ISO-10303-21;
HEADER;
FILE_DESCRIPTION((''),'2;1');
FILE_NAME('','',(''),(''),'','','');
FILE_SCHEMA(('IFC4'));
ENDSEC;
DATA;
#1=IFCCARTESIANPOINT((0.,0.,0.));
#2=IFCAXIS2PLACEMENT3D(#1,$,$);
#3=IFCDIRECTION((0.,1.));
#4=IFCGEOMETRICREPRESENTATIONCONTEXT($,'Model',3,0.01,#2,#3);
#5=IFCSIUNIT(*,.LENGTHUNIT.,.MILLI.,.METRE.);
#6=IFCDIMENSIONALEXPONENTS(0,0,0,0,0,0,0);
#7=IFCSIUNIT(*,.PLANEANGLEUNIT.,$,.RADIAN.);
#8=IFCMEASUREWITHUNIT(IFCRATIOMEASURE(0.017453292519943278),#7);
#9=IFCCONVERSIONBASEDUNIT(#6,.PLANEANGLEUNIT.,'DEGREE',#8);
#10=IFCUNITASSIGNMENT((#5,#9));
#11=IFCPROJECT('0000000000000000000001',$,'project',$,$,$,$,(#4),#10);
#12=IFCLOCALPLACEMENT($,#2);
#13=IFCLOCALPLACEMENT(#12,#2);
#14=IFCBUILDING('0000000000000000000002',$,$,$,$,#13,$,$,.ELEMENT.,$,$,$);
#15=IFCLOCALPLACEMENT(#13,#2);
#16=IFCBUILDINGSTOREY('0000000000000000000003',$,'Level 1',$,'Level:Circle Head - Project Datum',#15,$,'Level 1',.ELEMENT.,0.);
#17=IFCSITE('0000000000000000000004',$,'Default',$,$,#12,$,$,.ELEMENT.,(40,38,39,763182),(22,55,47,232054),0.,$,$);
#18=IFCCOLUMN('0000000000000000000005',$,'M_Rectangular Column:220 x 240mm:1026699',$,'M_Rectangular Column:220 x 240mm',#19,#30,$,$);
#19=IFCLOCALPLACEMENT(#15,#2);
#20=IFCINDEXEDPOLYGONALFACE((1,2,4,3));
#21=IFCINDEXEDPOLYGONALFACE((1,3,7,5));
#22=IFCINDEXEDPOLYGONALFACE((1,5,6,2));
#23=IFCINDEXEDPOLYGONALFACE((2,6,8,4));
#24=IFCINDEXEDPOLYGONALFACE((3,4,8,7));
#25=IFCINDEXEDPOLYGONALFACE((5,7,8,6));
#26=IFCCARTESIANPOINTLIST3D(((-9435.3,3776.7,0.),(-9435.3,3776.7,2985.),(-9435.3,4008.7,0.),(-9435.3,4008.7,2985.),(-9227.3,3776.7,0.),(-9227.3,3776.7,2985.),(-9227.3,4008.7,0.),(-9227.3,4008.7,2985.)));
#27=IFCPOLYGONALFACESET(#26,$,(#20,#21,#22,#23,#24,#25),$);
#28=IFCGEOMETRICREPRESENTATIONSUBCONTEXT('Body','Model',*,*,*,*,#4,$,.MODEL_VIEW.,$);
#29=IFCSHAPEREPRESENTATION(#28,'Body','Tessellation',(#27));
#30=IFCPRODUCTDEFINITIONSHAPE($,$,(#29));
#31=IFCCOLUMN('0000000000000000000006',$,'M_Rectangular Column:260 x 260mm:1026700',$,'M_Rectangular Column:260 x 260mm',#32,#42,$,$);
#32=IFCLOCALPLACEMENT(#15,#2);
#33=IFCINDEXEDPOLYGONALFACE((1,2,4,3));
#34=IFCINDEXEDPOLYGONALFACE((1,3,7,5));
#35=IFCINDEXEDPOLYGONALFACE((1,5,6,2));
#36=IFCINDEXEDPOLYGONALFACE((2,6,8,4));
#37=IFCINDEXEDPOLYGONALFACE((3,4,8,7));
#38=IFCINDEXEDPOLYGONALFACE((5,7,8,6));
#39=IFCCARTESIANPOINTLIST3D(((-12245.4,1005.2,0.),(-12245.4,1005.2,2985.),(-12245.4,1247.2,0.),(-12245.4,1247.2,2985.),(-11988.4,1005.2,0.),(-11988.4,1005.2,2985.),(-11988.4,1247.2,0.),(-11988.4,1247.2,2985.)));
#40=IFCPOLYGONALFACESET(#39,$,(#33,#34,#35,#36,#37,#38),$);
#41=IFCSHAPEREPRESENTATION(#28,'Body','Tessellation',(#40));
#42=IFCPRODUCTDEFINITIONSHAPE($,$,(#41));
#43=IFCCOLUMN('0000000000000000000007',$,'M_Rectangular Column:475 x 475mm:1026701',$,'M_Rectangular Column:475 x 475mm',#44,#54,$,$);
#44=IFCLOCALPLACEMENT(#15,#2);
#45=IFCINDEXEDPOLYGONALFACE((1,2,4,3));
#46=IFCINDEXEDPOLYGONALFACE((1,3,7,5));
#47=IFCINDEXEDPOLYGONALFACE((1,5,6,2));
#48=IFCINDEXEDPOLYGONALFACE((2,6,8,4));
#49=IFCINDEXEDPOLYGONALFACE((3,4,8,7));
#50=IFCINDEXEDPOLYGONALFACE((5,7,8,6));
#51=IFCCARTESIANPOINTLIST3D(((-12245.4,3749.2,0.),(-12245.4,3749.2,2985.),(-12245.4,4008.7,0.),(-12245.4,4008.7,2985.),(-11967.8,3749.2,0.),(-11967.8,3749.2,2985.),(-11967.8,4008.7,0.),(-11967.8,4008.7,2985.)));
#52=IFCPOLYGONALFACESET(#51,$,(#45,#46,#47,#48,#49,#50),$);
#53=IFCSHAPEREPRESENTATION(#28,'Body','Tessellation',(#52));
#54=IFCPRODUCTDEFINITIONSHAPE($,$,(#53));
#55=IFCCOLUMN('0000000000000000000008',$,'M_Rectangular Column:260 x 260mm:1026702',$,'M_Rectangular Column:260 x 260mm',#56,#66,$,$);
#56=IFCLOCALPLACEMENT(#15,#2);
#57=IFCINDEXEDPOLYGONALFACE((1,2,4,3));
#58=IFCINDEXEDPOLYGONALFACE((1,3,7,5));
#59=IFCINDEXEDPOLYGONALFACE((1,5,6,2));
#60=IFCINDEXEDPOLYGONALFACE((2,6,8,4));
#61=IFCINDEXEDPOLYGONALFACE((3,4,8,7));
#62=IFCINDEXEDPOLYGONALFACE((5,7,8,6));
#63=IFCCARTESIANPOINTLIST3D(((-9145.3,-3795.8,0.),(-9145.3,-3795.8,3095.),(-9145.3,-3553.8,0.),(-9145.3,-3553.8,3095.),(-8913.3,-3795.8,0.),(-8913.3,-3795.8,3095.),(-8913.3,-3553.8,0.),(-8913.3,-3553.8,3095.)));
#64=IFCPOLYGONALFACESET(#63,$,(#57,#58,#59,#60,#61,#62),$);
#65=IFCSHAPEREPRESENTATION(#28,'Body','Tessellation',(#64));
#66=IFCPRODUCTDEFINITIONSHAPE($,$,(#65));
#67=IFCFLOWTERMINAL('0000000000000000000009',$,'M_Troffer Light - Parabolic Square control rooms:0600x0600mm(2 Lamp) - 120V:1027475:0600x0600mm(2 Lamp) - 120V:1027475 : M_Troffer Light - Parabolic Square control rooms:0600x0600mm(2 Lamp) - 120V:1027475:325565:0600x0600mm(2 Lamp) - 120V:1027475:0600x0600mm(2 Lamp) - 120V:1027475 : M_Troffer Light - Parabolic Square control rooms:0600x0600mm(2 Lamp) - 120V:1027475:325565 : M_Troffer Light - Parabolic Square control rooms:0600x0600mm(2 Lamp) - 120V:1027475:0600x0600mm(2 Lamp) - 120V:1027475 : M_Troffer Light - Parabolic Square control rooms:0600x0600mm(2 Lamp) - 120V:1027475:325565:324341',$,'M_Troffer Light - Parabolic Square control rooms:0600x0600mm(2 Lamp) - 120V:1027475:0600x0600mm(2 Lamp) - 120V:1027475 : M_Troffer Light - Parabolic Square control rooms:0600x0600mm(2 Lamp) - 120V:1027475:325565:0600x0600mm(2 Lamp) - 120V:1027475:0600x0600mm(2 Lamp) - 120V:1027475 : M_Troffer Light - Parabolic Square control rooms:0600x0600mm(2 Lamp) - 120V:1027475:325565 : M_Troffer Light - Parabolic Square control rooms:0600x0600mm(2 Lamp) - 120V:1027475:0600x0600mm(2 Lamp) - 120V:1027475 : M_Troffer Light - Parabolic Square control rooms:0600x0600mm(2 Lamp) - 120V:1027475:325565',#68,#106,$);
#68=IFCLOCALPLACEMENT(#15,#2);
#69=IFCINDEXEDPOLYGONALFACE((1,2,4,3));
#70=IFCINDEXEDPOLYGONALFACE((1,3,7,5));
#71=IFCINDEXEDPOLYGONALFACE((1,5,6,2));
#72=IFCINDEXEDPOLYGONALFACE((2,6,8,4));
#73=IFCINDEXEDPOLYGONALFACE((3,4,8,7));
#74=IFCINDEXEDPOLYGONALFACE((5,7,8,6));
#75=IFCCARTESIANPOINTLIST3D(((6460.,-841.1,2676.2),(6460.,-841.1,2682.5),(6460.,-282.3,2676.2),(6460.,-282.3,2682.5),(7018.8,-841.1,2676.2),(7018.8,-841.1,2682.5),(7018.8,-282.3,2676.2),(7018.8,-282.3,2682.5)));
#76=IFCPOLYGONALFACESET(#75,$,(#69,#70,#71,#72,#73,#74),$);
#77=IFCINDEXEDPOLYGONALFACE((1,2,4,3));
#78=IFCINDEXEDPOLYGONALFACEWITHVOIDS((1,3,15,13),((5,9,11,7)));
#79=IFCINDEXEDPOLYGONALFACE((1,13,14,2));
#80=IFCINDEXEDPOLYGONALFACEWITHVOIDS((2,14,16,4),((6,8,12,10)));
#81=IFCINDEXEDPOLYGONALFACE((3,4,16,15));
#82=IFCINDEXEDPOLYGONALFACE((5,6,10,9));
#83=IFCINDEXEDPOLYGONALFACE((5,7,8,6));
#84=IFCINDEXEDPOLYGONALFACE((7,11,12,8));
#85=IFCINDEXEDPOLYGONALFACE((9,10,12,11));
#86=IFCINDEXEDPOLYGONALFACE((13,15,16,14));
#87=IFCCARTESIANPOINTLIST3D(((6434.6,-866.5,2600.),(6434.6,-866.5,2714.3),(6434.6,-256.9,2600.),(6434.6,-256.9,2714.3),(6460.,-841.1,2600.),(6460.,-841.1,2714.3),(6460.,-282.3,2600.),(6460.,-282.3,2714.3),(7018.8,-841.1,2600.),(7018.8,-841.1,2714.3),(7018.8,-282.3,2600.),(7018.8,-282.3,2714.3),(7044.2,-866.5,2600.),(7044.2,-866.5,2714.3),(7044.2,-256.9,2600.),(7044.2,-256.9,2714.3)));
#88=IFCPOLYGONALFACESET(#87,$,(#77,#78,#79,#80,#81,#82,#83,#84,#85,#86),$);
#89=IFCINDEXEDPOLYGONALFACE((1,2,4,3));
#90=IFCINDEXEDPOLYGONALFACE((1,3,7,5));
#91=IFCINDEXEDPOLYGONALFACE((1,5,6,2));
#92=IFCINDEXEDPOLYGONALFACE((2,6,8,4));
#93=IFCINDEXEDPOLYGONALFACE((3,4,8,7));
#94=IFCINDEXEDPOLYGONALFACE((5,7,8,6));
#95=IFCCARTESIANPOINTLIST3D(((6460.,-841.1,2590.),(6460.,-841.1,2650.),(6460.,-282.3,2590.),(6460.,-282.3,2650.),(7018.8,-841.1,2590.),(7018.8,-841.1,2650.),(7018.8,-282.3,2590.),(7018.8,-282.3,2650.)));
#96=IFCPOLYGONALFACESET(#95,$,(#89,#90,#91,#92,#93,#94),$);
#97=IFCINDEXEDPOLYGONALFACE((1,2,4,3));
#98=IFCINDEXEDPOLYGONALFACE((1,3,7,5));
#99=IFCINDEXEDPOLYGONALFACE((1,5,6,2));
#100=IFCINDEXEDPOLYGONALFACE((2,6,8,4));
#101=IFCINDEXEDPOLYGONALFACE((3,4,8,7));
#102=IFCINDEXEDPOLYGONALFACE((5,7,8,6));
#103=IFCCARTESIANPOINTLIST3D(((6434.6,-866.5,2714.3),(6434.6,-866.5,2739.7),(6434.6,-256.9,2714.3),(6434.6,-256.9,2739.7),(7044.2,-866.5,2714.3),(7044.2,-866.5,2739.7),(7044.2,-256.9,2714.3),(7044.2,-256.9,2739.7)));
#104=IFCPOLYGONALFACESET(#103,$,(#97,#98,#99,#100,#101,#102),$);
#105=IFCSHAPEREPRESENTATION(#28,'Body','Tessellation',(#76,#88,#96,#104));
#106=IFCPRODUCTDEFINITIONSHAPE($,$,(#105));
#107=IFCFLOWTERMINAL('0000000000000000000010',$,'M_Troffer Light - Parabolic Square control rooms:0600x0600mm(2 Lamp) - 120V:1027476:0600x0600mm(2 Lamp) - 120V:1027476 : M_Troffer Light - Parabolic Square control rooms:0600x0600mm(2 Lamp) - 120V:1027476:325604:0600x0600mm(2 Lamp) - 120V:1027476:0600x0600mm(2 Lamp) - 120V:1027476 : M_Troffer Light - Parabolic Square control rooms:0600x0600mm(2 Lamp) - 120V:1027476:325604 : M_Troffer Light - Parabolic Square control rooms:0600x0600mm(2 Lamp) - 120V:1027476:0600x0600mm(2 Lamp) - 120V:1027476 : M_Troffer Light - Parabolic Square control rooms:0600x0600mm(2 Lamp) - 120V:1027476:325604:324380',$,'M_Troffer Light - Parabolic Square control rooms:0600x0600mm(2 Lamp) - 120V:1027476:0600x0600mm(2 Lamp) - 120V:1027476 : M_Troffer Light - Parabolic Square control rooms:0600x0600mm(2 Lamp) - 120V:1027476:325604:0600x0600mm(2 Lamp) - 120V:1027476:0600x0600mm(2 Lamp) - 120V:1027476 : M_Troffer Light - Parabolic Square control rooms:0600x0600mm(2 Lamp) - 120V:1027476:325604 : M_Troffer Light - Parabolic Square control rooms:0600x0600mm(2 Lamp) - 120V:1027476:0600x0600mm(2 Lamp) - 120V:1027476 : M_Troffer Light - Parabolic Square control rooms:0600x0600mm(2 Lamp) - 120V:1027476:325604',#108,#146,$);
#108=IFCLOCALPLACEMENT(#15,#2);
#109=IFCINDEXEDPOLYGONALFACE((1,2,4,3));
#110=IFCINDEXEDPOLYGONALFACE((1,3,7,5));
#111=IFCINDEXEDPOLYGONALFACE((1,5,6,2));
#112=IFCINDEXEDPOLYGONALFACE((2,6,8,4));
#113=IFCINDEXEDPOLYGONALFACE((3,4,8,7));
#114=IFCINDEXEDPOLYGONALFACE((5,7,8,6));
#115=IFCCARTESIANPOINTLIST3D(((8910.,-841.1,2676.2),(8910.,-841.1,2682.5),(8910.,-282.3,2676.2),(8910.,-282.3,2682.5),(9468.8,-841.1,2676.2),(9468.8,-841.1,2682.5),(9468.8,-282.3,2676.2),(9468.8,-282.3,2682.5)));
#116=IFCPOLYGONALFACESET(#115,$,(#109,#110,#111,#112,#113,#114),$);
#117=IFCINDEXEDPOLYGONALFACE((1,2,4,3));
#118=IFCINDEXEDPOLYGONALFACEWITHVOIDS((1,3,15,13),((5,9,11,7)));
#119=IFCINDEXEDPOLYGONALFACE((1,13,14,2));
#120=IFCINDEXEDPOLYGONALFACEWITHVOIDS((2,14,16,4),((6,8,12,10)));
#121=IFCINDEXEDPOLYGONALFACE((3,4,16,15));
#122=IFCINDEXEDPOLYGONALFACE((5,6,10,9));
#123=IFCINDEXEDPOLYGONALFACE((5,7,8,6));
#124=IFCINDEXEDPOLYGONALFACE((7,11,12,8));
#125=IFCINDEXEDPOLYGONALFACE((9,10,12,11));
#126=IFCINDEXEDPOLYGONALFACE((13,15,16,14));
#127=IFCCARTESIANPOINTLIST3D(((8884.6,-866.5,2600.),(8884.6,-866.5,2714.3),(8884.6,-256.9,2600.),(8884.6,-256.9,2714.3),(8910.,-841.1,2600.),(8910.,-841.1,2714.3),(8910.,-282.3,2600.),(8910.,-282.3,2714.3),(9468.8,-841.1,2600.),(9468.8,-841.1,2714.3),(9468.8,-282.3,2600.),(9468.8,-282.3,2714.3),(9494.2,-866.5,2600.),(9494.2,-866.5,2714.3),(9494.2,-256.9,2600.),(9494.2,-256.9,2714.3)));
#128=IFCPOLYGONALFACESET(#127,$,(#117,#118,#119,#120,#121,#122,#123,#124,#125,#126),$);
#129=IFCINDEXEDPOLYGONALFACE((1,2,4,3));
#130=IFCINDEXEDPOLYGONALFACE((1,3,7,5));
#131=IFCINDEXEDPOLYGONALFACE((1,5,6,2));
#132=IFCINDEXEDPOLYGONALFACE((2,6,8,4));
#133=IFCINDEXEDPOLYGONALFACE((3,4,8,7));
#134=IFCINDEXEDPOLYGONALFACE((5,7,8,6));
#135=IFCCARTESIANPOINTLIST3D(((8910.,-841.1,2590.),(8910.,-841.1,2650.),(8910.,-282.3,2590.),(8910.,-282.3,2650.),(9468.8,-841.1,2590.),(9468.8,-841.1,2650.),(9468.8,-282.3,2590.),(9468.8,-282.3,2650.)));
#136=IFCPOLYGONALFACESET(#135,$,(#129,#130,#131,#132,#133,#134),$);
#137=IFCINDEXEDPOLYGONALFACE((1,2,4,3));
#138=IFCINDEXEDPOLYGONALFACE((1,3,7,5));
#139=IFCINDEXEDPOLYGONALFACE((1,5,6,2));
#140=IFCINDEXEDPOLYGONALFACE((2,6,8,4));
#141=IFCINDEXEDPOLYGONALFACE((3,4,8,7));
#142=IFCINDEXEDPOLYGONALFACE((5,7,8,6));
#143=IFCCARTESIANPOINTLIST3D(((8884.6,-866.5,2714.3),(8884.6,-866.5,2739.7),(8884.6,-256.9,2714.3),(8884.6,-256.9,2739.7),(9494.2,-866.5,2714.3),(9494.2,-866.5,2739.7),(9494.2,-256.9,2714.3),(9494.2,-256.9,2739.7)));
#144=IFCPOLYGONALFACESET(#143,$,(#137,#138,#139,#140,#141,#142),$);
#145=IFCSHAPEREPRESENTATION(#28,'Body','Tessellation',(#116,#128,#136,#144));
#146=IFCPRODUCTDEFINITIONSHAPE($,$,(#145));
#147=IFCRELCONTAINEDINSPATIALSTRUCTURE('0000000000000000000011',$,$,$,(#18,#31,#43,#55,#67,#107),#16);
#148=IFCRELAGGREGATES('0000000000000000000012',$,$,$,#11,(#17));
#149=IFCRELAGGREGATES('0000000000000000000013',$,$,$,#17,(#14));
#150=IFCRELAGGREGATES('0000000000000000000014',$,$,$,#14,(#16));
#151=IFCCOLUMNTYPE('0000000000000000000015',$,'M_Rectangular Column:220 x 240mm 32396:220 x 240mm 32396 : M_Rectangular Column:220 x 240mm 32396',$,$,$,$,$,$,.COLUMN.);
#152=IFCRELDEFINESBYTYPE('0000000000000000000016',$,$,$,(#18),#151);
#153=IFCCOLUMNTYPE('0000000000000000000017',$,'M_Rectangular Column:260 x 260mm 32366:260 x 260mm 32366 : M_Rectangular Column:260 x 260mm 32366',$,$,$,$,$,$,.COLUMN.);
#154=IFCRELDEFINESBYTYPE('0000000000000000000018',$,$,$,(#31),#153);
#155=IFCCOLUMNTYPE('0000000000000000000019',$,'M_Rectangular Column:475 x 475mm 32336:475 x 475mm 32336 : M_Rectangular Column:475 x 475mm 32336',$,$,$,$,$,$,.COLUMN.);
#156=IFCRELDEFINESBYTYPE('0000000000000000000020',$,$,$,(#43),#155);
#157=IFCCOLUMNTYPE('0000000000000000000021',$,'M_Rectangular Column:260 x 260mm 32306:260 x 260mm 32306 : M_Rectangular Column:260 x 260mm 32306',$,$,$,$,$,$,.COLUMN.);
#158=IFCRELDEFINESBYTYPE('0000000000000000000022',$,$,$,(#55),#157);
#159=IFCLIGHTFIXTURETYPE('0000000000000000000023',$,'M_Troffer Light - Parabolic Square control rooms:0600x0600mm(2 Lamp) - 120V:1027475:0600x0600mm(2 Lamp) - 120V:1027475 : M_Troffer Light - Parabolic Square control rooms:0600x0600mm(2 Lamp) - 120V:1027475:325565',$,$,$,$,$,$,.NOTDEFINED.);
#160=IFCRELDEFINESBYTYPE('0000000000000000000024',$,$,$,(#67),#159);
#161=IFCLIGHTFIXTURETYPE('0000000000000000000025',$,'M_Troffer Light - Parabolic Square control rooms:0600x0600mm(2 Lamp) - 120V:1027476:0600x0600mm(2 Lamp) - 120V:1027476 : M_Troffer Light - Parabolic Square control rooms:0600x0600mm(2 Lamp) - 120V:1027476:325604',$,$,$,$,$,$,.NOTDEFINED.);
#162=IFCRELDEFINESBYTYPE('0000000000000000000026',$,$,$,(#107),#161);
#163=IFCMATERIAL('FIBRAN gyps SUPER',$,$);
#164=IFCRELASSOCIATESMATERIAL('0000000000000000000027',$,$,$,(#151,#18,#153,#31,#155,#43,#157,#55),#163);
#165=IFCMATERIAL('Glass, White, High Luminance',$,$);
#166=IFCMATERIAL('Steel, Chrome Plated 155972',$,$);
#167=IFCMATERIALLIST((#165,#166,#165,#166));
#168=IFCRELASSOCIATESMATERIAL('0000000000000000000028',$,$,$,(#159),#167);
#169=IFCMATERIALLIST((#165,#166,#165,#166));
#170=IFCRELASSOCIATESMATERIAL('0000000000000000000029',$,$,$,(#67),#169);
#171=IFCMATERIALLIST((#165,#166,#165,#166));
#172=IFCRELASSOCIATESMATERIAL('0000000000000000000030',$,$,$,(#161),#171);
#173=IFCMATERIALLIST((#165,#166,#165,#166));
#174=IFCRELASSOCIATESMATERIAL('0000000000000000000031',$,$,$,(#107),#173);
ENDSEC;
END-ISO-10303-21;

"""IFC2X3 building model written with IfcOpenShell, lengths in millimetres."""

from ifc_helpers import new_model, entity, si_unit, converted_unit, direction, frame, frame_2d, origin, origin_2d_with_axis, place, context, subcontext, project, spatial, polyline, rectangle, outline, extrude, source, transform, mapped, material, material_list, type_object, type_shapes, element, save


model = new_model("IFC2X3")

# Units and contexts
model_context = context("Model", 3, precision=0.01, world=origin(), true_north=direction((0.0, 1.0)))
body_context = subcontext(model_context, "Body", "Model", "MODEL_VIEW")
ifc_project = project(units=[si_unit("LENGTHUNIT", "METRE", prefix="MILLI"), converted_unit("PLANEANGLEUNIT", "DEGREE", entity("IfcRatioMeasure", 0.017453292519943278), si_unit("PLANEANGLEUNIT", "RADIAN"), dimensions=[0, 0, 0, 0, 0, 0, 0])], contexts=[model_context])

# Site, building, storey
site_placement = place(None, origin())
site = spatial("IfcSite", under=ifc_project, at=site_placement, Name="Default", CompositionType="ELEMENT", RefLatitude=(40, 38, 39, 763182), RefLongitude=(22, 55, 47, 232054), RefElevation=0.0)
building_placement = place(site_placement, origin())
building = spatial("IfcBuilding", under=site, at=building_placement, CompositionType="ELEMENT")
storey_placement = place(building_placement, origin())
storey = spatial("IfcBuildingStorey", under=building, at=storey_placement, Name="Level 1", ObjectType="Level:Circle Head - Project Datum", LongName="Level 1", CompositionType="ELEMENT", Elevation=0.0)

# Columns
ifc_material_1 = material(Name="FIBRAN gyps SUPER")
column_type_1 = type_object("IfcColumnType", Name="M_Rectangular Column:220 x 240mm 32396:220 x 240mm 32396 : M_Rectangular Column:220 x 240mm 32396", PredefinedType="COLUMN", material=ifc_material_1)
shared_shape_1 = source(origin(), body_context, "Body", "SweptSolid", [
    extrude(rectangle(XDim=232.0, YDim=208.0, at=frame_2d((0.0, 0.0), x_axis=(1.0, 0.0))), frame((-9331.3, 3892.7, 0.0), z_axis=(0.0, 0.0, 1.0), x_axis=(0.0, -1.0, 0.0)), (0.0, 0.0, 1.0), 2985.0),
])
type_shapes(column_type_1, [shared_shape_1])
column_1_placement = place(storey_placement, origin())
element("IfcColumn", 1, at=column_1_placement, inside=storey, type_object=column_type_1, material=ifc_material_1, Name="M_Rectangular Column:220 x 240mm:1026699", ObjectType="M_Rectangular Column:220 x 240mm", context=body_context, shape_type="MappedRepresentation", body=[
    mapped(shared_shape_1, transform((0.0, 0.0, 0.0), scale=1.0)),
])
column_type_2 = type_object("IfcColumnType", Name="M_Rectangular Column:260 x 260mm 32366:260 x 260mm 32366 : M_Rectangular Column:260 x 260mm 32366", PredefinedType="COLUMN", material=ifc_material_1)
shared_shape_2 = source(origin(), body_context, "Body", "SweptSolid", [
    extrude(rectangle(XDim=242.0, YDim=257.0, at=frame_2d((0.0, 0.0), x_axis=(1.0, 0.0))), frame((-12116.9, 1126.2, 0.0), z_axis=(0.0, 0.0, 1.0), x_axis=(0.0, -1.0, 0.0)), (0.0, 0.0, 1.0), 2985.0),
])
type_shapes(column_type_2, [shared_shape_2])
column_2_placement = place(storey_placement, origin())
element("IfcColumn", 2, at=column_2_placement, inside=storey, type_object=column_type_2, material=ifc_material_1, Name="M_Rectangular Column:260 x 260mm:1026700", ObjectType="M_Rectangular Column:260 x 260mm", context=body_context, shape_type="MappedRepresentation", body=[
    mapped(shared_shape_2, transform((0.0, 0.0, 0.0), scale=1.0)),
])
column_type_3 = type_object("IfcColumnType", Name="M_Rectangular Column:475 x 475mm 32336:475 x 475mm 32336 : M_Rectangular Column:475 x 475mm 32336", PredefinedType="COLUMN", material=ifc_material_1)
shared_shape_3 = source(origin(), body_context, "Body", "SweptSolid", [
    extrude(rectangle(XDim=259.5, YDim=277.5, at=origin_2d_with_axis()), frame((-12106.6, 3878.9, 0.0), z_axis=(0.0, 0.0, 1.0), x_axis=(0.0, -1.0, 0.0)), (0.0, 0.0, 1.0), 2985.0),
])
type_shapes(column_type_3, [shared_shape_3])
column_3_placement = place(storey_placement, origin())
element("IfcColumn", 3, at=column_3_placement, inside=storey, type_object=column_type_3, material=ifc_material_1, Name="M_Rectangular Column:475 x 475mm:1026701", ObjectType="M_Rectangular Column:475 x 475mm", context=body_context, shape_type="MappedRepresentation", body=[
    mapped(shared_shape_3, transform((0.0, 0.0, 0.0), scale=1.0)),
])
column_type_4 = type_object("IfcColumnType", Name="M_Rectangular Column:260 x 260mm 32306:260 x 260mm 32306 : M_Rectangular Column:260 x 260mm 32306", PredefinedType="COLUMN", material=ifc_material_1)
shared_shape_4 = source(origin(), body_context, "Body", "SweptSolid", [
    extrude(rectangle(XDim=242.0, YDim=232.0, at=origin_2d_with_axis()), frame((-9029.3, -3674.8, 0.0), z_axis=(0.0, 0.0, 1.0), x_axis=(0.0, -1.0, 0.0)), (0.0, 0.0, 1.0), 3095.0),
])
type_shapes(column_type_4, [shared_shape_4])
column_4_placement = place(storey_placement, origin())
element("IfcColumn", 4, at=column_4_placement, inside=storey, type_object=column_type_4, material=ifc_material_1, Name="M_Rectangular Column:260 x 260mm:1026702", ObjectType="M_Rectangular Column:260 x 260mm", context=body_context, shape_type="MappedRepresentation", body=[
    mapped(shared_shape_4, transform((0.0, 0.0, 0.0), scale=1.0)),
])

# Flow terminals
ifc_material_2 = material(Name="Glass, White, High Luminance")
ifc_material_3 = material(Name="Steel, Chrome Plated 155972")
ifc_material_list_1 = material_list([ifc_material_2, ifc_material_3, ifc_material_2, ifc_material_3])
ifc_material_list_2 = material_list([ifc_material_2, ifc_material_3, ifc_material_2, ifc_material_3])
light_fixture_type_1 = type_object("IfcLightFixtureType", Name="M_Troffer Light - Parabolic Square control rooms:0600x0600mm(2 Lamp) - 120V:1027475:0600x0600mm(2 Lamp) - 120V:1027475 : M_Troffer Light - Parabolic Square control rooms:0600x0600mm(2 Lamp) - 120V:1027475:325565", PredefinedType="NOTDEFINED", material=ifc_material_list_2)
shared_shape_5 = source(origin(), body_context, "Body", "SweptSolid", [
    extrude(rectangle(XDim=558.8, YDim=558.8, at=frame_2d((0.0, 0.0), x_axis=(1.0, 0.0))), frame((6739.4, -561.7, 2676.2), z_axis=(0.0, 0.0, 1.0), x_axis=(0.0, 1.0, 0.0)), (0.0, 0.0, 1.0), 6.4),
    extrude(outline(polyline([(-304.8, -304.8), (304.8, -304.8), (304.8, 304.8), (-304.8, 304.8), (-304.8, -304.8)]), holes=[polyline([(279.4, 279.4), (279.4, -279.4), (-279.4, -279.4), (-279.4, 279.4), (279.4, 279.4)])]), frame((6739.4, -561.7, 2600.0), z_axis=(0.0, 0.0, 1.0), x_axis=(0.0, -1.0, 0.0)), (0.0, 0.0, 1.0), 114.3),
    extrude(rectangle(XDim=558.8, YDim=558.8, at=frame_2d((0.0, 0.0), x_axis=(1.0, 0.0))), frame((6739.4, -561.7, 2590.0), z_axis=(0.0, 0.0, 1.0), x_axis=(0.0, 1.0, 0.0)), (0.0, 0.0, 1.0), 60.0),
    extrude(rectangle(XDim=609.6, YDim=609.6, at=origin_2d_with_axis()), frame((6739.4, -561.7, 2714.3), z_axis=(0.0, 0.0, 1.0), x_axis=(0.0, 1.0, 0.0)), (0.0, 0.0, 1.0), 25.4),
])
type_shapes(light_fixture_type_1, [shared_shape_5])
flow_terminal_1_placement = place(storey_placement, origin())
element("IfcFlowTerminal", 5, at=flow_terminal_1_placement, inside=storey, type_object=light_fixture_type_1, material=ifc_material_list_1, Name="M_Troffer Light - Parabolic Square control rooms:0600x0600mm(2 Lamp) - 120V:1027475:0600x0600mm(2 Lamp) - 120V:1027475 : M_Troffer Light - Parabolic Square control rooms:0600x0600mm(2 Lamp) - 120V:1027475:325565:0600x0600mm(2 Lamp) - 120V:1027475:0600x0600mm(2 Lamp) - 120V:1027475 : M_Troffer Light - Parabolic Square control rooms:0600x0600mm(2 Lamp) - 120V:1027475:325565 : M_Troffer Light - Parabolic Square control rooms:0600x0600mm(2 Lamp) - 120V:1027475:0600x0600mm(2 Lamp) - 120V:1027475 : M_Troffer Light - Parabolic Square control rooms:0600x0600mm(2 Lamp) - 120V:1027475:325565:324341", ObjectType="M_Troffer Light - Parabolic Square control rooms:0600x0600mm(2 Lamp) - 120V:1027475:0600x0600mm(2 Lamp) - 120V:1027475 : M_Troffer Light - Parabolic Square control rooms:0600x0600mm(2 Lamp) - 120V:1027475:325565:0600x0600mm(2 Lamp) - 120V:1027475:0600x0600mm(2 Lamp) - 120V:1027475 : M_Troffer Light - Parabolic Square control rooms:0600x0600mm(2 Lamp) - 120V:1027475:325565 : M_Troffer Light - Parabolic Square control rooms:0600x0600mm(2 Lamp) - 120V:1027475:0600x0600mm(2 Lamp) - 120V:1027475 : M_Troffer Light - Parabolic Square control rooms:0600x0600mm(2 Lamp) - 120V:1027475:325565", context=body_context, shape_type="MappedRepresentation", body=[
    mapped(shared_shape_5, transform((0.0, 0.0, 0.0), scale=1.0)),
])
ifc_material_list_3 = material_list([ifc_material_2, ifc_material_3, ifc_material_2, ifc_material_3])
ifc_material_list_4 = material_list([ifc_material_2, ifc_material_3, ifc_material_2, ifc_material_3])
light_fixture_type_2 = type_object("IfcLightFixtureType", Name="M_Troffer Light - Parabolic Square control rooms:0600x0600mm(2 Lamp) - 120V:1027476:0600x0600mm(2 Lamp) - 120V:1027476 : M_Troffer Light - Parabolic Square control rooms:0600x0600mm(2 Lamp) - 120V:1027476:325604", PredefinedType="NOTDEFINED", material=ifc_material_list_4)
shared_shape_6 = source(origin(), body_context, "Body", "SweptSolid", [
    extrude(rectangle(XDim=558.8, YDim=558.8, at=origin_2d_with_axis()), frame((9189.4, -561.7, 2676.2), z_axis=(0.0, 0.0, 1.0), x_axis=(0.0, 1.0, 0.0)), (0.0, 0.0, 1.0), 6.4),
    extrude(outline(polyline([(-304.8, -304.8), (304.8, -304.8), (304.8, 304.8), (-304.8, 304.8), (-304.8, -304.8)]), holes=[polyline([(279.4, 279.4), (279.4, -279.4), (-279.4, -279.4), (-279.4, 279.4), (279.4, 279.4)])]), frame((9189.4, -561.7, 2600.0), z_axis=(0.0, 0.0, 1.0), x_axis=(0.0, -1.0, 0.0)), (0.0, 0.0, 1.0), 114.3),
    extrude(rectangle(XDim=558.8, YDim=558.8, at=frame_2d((0.0, 0.0), x_axis=(1.0, 0.0))), frame((9189.4, -561.7, 2590.0), z_axis=(0.0, 0.0, 1.0), x_axis=(0.0, 1.0, 0.0)), (0.0, 0.0, 1.0), 60.0),
    extrude(rectangle(XDim=609.6, YDim=609.6, at=origin_2d_with_axis()), frame((9189.4, -561.7, 2714.3), z_axis=(0.0, 0.0, 1.0), x_axis=(0.0, 1.0, 0.0)), (0.0, 0.0, 1.0), 25.4),
])
type_shapes(light_fixture_type_2, [shared_shape_6])
flow_terminal_2_placement = place(storey_placement, origin())
element("IfcFlowTerminal", 6, at=flow_terminal_2_placement, inside=storey, type_object=light_fixture_type_2, material=ifc_material_list_3, Name="M_Troffer Light - Parabolic Square control rooms:0600x0600mm(2 Lamp) - 120V:1027476:0600x0600mm(2 Lamp) - 120V:1027476 : M_Troffer Light - Parabolic Square control rooms:0600x0600mm(2 Lamp) - 120V:1027476:325604:0600x0600mm(2 Lamp) - 120V:1027476:0600x0600mm(2 Lamp) - 120V:1027476 : M_Troffer Light - Parabolic Square control rooms:0600x0600mm(2 Lamp) - 120V:1027476:325604 : M_Troffer Light - Parabolic Square control rooms:0600x0600mm(2 Lamp) - 120V:1027476:0600x0600mm(2 Lamp) - 120V:1027476 : M_Troffer Light - Parabolic Square control rooms:0600x0600mm(2 Lamp) - 120V:1027476:325604:324380", ObjectType="M_Troffer Light - Parabolic Square control rooms:0600x0600mm(2 Lamp) - 120V:1027476:0600x0600mm(2 Lamp) - 120V:1027476 : M_Troffer Light - Parabolic Square control rooms:0600x0600mm(2 Lamp) - 120V:1027476:325604:0600x0600mm(2 Lamp) - 120V:1027476:0600x0600mm(2 Lamp) - 120V:1027476 : M_Troffer Light - Parabolic Square control rooms:0600x0600mm(2 Lamp) - 120V:1027476:325604 : M_Troffer Light - Parabolic Square control rooms:0600x0600mm(2 Lamp) - 120V:1027476:0600x0600mm(2 Lamp) - 120V:1027476 : M_Troffer Light - Parabolic Square control rooms:0600x0600mm(2 Lamp) - 120V:1027476:325604", context=body_context, shape_type="MappedRepresentation", body=[
    mapped(shared_shape_6, transform((0.0, 0.0, 0.0), scale=1.0)),
])

save(model, "model.ifc")
